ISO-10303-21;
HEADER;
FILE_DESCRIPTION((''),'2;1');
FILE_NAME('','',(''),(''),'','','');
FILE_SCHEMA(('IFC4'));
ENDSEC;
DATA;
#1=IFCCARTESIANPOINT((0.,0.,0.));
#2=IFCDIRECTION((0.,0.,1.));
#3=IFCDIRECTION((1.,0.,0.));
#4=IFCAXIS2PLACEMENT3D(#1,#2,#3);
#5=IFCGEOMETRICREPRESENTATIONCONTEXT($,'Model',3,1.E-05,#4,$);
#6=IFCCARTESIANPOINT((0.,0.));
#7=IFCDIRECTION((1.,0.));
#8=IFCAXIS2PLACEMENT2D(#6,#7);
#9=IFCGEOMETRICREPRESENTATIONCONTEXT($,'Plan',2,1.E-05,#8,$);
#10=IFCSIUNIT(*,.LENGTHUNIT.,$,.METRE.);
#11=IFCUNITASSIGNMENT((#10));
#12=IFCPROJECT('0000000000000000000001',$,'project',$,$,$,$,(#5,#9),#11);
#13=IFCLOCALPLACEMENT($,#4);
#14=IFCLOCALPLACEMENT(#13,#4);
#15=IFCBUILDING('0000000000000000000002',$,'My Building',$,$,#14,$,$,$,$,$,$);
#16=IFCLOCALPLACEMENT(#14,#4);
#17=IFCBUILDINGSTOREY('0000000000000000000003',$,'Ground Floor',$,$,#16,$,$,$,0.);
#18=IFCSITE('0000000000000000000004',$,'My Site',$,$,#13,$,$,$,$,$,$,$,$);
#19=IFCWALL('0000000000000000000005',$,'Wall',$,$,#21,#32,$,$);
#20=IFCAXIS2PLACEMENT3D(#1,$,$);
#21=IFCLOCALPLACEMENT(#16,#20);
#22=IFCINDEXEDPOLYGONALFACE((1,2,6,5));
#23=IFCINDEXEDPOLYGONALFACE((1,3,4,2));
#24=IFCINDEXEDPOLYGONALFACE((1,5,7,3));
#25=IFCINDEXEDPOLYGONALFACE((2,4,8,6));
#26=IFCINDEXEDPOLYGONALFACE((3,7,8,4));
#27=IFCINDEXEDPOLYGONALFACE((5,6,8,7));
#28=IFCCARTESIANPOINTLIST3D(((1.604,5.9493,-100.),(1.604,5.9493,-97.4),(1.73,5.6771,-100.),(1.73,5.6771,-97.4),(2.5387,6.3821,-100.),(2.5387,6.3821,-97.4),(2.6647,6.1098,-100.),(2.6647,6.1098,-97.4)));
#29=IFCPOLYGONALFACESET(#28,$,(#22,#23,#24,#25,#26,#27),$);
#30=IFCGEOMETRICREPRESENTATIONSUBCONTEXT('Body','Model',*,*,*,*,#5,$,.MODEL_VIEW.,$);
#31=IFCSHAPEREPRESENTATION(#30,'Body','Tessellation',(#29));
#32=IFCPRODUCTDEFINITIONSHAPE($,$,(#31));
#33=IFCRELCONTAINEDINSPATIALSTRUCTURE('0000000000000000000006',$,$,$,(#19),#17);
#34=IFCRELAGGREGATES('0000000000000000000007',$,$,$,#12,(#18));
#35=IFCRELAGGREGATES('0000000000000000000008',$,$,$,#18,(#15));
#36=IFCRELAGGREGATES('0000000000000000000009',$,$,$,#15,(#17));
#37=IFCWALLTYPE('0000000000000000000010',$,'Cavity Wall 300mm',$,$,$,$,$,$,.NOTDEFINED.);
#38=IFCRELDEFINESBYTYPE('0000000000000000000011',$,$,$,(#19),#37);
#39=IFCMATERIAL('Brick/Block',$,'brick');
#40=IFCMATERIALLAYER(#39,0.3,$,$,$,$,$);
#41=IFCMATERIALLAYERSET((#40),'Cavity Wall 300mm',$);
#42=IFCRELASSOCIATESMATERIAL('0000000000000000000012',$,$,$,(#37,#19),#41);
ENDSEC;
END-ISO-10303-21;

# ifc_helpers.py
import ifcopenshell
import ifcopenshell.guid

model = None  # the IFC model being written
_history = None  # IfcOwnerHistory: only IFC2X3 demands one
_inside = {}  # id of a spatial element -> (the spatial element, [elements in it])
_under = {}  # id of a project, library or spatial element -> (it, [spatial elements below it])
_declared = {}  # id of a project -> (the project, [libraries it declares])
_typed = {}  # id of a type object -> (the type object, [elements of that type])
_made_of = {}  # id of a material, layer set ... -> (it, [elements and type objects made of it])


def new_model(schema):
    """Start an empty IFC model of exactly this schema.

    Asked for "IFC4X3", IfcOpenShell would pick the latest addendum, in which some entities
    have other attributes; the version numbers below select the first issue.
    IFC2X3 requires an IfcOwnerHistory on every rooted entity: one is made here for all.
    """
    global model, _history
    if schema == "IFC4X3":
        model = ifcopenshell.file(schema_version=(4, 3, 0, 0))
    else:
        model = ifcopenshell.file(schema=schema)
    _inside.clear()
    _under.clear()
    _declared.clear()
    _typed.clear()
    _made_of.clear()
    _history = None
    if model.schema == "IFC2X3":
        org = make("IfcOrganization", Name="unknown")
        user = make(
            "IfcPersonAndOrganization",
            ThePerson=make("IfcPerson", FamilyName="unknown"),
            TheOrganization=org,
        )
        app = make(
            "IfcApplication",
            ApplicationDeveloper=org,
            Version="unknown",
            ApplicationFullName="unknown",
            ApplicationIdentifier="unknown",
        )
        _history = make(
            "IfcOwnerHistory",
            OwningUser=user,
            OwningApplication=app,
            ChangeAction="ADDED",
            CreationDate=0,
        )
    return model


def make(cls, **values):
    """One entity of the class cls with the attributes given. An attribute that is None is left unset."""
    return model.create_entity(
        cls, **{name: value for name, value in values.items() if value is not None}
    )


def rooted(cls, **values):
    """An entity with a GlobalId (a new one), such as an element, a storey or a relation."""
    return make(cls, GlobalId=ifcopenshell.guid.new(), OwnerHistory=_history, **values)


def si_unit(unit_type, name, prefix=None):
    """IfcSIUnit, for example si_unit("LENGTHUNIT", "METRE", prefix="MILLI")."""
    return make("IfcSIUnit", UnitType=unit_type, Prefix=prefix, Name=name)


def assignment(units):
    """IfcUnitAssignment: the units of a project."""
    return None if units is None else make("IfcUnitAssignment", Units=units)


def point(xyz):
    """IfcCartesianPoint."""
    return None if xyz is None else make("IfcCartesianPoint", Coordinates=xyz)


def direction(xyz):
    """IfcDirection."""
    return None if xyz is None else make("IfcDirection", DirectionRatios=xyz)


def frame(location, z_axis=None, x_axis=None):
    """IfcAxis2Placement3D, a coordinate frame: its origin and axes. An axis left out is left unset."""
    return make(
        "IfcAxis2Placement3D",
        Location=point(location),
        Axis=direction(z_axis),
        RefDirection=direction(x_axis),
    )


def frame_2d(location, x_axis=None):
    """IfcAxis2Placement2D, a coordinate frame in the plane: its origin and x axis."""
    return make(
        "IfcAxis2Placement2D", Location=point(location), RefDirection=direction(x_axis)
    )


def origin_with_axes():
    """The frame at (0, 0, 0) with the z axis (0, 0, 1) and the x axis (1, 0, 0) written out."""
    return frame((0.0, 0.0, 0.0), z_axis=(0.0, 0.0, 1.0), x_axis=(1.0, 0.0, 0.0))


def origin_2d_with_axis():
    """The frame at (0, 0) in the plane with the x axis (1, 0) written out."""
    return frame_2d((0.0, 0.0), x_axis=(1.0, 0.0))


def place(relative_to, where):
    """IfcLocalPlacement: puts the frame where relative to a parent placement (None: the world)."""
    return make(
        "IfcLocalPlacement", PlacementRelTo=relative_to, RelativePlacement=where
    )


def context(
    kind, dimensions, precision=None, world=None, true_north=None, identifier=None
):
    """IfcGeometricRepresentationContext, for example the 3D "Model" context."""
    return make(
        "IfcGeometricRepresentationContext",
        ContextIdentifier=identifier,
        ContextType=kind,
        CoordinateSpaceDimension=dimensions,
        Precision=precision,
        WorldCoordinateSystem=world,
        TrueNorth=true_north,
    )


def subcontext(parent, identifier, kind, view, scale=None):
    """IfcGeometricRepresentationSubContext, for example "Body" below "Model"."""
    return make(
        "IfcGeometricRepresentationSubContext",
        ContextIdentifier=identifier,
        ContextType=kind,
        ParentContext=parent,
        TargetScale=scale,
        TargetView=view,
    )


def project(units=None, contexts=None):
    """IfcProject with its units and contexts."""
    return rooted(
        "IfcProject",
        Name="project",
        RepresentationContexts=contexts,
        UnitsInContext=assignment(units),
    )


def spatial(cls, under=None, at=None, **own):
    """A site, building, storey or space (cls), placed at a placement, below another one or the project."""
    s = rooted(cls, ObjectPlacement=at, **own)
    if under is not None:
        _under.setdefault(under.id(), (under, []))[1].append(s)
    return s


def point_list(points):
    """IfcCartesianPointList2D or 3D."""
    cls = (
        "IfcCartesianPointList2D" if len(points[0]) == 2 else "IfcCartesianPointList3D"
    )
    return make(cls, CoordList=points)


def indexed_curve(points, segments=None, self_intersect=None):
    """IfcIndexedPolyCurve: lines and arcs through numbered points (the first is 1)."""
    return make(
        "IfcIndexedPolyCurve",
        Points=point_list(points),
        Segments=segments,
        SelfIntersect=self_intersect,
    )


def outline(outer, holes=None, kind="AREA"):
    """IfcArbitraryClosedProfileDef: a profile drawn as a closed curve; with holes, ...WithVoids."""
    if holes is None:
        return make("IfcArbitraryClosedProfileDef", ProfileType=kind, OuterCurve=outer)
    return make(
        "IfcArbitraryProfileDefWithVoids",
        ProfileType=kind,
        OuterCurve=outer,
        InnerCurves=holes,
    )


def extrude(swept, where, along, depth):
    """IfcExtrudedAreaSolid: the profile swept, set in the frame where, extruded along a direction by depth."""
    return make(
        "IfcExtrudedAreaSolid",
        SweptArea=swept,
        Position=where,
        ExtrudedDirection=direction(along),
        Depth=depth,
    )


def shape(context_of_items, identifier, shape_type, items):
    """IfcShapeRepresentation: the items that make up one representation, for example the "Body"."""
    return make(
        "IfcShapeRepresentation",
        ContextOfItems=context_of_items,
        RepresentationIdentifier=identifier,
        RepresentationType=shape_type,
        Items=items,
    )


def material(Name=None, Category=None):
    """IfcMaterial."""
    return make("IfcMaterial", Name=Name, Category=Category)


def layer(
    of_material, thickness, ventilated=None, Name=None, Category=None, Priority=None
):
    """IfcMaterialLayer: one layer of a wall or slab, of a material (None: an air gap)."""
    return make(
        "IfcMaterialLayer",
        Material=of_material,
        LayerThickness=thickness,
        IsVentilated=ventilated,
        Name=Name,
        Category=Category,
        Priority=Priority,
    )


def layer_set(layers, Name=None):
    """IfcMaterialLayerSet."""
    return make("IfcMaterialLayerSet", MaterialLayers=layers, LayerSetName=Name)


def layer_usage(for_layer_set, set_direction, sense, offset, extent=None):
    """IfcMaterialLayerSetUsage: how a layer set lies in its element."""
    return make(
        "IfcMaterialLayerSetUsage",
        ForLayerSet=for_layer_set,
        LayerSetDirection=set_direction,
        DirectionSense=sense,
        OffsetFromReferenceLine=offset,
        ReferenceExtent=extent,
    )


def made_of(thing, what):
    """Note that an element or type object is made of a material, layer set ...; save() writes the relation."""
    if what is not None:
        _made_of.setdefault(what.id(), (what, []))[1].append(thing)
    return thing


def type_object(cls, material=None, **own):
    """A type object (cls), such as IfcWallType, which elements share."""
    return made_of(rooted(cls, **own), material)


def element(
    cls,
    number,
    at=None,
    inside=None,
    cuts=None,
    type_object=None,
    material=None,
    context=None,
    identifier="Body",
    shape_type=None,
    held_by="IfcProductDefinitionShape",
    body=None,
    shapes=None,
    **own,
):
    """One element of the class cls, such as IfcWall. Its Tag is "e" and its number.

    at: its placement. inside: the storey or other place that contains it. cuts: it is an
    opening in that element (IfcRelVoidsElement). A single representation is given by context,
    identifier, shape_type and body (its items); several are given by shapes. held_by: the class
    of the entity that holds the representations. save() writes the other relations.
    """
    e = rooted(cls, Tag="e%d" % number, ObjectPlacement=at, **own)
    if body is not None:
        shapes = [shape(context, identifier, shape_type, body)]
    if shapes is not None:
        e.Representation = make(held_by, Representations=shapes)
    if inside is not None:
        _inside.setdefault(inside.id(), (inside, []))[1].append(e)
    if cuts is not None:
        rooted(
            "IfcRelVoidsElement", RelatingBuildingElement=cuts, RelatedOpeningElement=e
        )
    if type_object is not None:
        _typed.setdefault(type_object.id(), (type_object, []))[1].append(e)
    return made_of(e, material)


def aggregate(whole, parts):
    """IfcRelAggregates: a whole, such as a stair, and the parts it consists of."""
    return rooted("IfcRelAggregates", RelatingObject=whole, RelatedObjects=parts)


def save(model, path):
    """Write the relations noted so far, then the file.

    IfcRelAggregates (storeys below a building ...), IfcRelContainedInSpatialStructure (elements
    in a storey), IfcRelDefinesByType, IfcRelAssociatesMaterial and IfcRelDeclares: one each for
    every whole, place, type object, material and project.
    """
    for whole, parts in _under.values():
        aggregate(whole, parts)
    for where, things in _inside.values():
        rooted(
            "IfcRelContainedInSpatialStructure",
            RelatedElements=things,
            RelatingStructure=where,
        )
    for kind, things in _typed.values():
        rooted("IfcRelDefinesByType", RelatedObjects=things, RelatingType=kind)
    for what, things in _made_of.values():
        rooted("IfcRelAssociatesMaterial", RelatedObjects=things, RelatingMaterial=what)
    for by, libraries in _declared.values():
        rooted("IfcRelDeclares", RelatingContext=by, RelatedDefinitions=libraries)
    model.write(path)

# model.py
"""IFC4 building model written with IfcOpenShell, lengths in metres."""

from ifc_helpers import new_model, si_unit, frame, origin_with_axes, origin_2d_with_axis, place, context, subcontext, project, spatial, indexed_curve, outline, extrude, material, layer, layer_set, layer_usage, type_object, element, save


model = new_model("IFC4")

# Units and contexts
model_context = context("Model", 3, precision=1e-05, world=origin_with_axes())
plan_context = context("Plan", 2, precision=1e-05, world=origin_2d_with_axis())
body_context = subcontext(model_context, "Body", "Model", "MODEL_VIEW")
ifc_project = project(units=[si_unit("LENGTHUNIT", "METRE")], contexts=[model_context, plan_context])

# Site, building, storey
site_placement = place(None, origin_with_axes())
site = spatial("IfcSite", under=ifc_project, at=site_placement, Name="My Site")
building_placement = place(site_placement, origin_with_axes())
building = spatial("IfcBuilding", under=site, at=building_placement, Name="My Building")
storey_placement = place(building_placement, origin_with_axes())
storey = spatial("IfcBuildingStorey", under=building, at=storey_placement, Name="Ground Floor", Elevation=0.0)

# Wall
ifc_material = material(Name="Brick/Block", Category="brick")
ifc_layer = layer(ifc_material, 0.3)
ifc_layer_set = layer_set([ifc_layer], Name="Cavity Wall 300mm")
ifc_layer_usage = layer_usage(ifc_layer_set, "AXIS2", "POSITIVE", 0.0)
wall_type = type_object("IfcWallType", Name="Cavity Wall 300mm", PredefinedType="NOTDEFINED", material=ifc_layer_set)
wall_placement = place(storey_placement, frame((1.73, 5.6771, -100.0), z_axis=(0.0, 0.0, 1.0), x_axis=(0.907469, 0.420118, 0.0)))
element("IfcWall", 1, at=wall_placement, inside=storey, type_object=wall_type, material=ifc_layer_usage, Name="Wall", context=body_context, shape_type="SweptSolid", body=[
    extrude(outline(indexed_curve([(0.0, 0.0), (0.0, 0.3), (1.03, 0.3), (1.03, 0.0), (0.0, 0.0)], self_intersect=False)), origin_with_axes(), (0.0, 0.0, 1.0), 2.6),
])

save(model, "model.ifc")
